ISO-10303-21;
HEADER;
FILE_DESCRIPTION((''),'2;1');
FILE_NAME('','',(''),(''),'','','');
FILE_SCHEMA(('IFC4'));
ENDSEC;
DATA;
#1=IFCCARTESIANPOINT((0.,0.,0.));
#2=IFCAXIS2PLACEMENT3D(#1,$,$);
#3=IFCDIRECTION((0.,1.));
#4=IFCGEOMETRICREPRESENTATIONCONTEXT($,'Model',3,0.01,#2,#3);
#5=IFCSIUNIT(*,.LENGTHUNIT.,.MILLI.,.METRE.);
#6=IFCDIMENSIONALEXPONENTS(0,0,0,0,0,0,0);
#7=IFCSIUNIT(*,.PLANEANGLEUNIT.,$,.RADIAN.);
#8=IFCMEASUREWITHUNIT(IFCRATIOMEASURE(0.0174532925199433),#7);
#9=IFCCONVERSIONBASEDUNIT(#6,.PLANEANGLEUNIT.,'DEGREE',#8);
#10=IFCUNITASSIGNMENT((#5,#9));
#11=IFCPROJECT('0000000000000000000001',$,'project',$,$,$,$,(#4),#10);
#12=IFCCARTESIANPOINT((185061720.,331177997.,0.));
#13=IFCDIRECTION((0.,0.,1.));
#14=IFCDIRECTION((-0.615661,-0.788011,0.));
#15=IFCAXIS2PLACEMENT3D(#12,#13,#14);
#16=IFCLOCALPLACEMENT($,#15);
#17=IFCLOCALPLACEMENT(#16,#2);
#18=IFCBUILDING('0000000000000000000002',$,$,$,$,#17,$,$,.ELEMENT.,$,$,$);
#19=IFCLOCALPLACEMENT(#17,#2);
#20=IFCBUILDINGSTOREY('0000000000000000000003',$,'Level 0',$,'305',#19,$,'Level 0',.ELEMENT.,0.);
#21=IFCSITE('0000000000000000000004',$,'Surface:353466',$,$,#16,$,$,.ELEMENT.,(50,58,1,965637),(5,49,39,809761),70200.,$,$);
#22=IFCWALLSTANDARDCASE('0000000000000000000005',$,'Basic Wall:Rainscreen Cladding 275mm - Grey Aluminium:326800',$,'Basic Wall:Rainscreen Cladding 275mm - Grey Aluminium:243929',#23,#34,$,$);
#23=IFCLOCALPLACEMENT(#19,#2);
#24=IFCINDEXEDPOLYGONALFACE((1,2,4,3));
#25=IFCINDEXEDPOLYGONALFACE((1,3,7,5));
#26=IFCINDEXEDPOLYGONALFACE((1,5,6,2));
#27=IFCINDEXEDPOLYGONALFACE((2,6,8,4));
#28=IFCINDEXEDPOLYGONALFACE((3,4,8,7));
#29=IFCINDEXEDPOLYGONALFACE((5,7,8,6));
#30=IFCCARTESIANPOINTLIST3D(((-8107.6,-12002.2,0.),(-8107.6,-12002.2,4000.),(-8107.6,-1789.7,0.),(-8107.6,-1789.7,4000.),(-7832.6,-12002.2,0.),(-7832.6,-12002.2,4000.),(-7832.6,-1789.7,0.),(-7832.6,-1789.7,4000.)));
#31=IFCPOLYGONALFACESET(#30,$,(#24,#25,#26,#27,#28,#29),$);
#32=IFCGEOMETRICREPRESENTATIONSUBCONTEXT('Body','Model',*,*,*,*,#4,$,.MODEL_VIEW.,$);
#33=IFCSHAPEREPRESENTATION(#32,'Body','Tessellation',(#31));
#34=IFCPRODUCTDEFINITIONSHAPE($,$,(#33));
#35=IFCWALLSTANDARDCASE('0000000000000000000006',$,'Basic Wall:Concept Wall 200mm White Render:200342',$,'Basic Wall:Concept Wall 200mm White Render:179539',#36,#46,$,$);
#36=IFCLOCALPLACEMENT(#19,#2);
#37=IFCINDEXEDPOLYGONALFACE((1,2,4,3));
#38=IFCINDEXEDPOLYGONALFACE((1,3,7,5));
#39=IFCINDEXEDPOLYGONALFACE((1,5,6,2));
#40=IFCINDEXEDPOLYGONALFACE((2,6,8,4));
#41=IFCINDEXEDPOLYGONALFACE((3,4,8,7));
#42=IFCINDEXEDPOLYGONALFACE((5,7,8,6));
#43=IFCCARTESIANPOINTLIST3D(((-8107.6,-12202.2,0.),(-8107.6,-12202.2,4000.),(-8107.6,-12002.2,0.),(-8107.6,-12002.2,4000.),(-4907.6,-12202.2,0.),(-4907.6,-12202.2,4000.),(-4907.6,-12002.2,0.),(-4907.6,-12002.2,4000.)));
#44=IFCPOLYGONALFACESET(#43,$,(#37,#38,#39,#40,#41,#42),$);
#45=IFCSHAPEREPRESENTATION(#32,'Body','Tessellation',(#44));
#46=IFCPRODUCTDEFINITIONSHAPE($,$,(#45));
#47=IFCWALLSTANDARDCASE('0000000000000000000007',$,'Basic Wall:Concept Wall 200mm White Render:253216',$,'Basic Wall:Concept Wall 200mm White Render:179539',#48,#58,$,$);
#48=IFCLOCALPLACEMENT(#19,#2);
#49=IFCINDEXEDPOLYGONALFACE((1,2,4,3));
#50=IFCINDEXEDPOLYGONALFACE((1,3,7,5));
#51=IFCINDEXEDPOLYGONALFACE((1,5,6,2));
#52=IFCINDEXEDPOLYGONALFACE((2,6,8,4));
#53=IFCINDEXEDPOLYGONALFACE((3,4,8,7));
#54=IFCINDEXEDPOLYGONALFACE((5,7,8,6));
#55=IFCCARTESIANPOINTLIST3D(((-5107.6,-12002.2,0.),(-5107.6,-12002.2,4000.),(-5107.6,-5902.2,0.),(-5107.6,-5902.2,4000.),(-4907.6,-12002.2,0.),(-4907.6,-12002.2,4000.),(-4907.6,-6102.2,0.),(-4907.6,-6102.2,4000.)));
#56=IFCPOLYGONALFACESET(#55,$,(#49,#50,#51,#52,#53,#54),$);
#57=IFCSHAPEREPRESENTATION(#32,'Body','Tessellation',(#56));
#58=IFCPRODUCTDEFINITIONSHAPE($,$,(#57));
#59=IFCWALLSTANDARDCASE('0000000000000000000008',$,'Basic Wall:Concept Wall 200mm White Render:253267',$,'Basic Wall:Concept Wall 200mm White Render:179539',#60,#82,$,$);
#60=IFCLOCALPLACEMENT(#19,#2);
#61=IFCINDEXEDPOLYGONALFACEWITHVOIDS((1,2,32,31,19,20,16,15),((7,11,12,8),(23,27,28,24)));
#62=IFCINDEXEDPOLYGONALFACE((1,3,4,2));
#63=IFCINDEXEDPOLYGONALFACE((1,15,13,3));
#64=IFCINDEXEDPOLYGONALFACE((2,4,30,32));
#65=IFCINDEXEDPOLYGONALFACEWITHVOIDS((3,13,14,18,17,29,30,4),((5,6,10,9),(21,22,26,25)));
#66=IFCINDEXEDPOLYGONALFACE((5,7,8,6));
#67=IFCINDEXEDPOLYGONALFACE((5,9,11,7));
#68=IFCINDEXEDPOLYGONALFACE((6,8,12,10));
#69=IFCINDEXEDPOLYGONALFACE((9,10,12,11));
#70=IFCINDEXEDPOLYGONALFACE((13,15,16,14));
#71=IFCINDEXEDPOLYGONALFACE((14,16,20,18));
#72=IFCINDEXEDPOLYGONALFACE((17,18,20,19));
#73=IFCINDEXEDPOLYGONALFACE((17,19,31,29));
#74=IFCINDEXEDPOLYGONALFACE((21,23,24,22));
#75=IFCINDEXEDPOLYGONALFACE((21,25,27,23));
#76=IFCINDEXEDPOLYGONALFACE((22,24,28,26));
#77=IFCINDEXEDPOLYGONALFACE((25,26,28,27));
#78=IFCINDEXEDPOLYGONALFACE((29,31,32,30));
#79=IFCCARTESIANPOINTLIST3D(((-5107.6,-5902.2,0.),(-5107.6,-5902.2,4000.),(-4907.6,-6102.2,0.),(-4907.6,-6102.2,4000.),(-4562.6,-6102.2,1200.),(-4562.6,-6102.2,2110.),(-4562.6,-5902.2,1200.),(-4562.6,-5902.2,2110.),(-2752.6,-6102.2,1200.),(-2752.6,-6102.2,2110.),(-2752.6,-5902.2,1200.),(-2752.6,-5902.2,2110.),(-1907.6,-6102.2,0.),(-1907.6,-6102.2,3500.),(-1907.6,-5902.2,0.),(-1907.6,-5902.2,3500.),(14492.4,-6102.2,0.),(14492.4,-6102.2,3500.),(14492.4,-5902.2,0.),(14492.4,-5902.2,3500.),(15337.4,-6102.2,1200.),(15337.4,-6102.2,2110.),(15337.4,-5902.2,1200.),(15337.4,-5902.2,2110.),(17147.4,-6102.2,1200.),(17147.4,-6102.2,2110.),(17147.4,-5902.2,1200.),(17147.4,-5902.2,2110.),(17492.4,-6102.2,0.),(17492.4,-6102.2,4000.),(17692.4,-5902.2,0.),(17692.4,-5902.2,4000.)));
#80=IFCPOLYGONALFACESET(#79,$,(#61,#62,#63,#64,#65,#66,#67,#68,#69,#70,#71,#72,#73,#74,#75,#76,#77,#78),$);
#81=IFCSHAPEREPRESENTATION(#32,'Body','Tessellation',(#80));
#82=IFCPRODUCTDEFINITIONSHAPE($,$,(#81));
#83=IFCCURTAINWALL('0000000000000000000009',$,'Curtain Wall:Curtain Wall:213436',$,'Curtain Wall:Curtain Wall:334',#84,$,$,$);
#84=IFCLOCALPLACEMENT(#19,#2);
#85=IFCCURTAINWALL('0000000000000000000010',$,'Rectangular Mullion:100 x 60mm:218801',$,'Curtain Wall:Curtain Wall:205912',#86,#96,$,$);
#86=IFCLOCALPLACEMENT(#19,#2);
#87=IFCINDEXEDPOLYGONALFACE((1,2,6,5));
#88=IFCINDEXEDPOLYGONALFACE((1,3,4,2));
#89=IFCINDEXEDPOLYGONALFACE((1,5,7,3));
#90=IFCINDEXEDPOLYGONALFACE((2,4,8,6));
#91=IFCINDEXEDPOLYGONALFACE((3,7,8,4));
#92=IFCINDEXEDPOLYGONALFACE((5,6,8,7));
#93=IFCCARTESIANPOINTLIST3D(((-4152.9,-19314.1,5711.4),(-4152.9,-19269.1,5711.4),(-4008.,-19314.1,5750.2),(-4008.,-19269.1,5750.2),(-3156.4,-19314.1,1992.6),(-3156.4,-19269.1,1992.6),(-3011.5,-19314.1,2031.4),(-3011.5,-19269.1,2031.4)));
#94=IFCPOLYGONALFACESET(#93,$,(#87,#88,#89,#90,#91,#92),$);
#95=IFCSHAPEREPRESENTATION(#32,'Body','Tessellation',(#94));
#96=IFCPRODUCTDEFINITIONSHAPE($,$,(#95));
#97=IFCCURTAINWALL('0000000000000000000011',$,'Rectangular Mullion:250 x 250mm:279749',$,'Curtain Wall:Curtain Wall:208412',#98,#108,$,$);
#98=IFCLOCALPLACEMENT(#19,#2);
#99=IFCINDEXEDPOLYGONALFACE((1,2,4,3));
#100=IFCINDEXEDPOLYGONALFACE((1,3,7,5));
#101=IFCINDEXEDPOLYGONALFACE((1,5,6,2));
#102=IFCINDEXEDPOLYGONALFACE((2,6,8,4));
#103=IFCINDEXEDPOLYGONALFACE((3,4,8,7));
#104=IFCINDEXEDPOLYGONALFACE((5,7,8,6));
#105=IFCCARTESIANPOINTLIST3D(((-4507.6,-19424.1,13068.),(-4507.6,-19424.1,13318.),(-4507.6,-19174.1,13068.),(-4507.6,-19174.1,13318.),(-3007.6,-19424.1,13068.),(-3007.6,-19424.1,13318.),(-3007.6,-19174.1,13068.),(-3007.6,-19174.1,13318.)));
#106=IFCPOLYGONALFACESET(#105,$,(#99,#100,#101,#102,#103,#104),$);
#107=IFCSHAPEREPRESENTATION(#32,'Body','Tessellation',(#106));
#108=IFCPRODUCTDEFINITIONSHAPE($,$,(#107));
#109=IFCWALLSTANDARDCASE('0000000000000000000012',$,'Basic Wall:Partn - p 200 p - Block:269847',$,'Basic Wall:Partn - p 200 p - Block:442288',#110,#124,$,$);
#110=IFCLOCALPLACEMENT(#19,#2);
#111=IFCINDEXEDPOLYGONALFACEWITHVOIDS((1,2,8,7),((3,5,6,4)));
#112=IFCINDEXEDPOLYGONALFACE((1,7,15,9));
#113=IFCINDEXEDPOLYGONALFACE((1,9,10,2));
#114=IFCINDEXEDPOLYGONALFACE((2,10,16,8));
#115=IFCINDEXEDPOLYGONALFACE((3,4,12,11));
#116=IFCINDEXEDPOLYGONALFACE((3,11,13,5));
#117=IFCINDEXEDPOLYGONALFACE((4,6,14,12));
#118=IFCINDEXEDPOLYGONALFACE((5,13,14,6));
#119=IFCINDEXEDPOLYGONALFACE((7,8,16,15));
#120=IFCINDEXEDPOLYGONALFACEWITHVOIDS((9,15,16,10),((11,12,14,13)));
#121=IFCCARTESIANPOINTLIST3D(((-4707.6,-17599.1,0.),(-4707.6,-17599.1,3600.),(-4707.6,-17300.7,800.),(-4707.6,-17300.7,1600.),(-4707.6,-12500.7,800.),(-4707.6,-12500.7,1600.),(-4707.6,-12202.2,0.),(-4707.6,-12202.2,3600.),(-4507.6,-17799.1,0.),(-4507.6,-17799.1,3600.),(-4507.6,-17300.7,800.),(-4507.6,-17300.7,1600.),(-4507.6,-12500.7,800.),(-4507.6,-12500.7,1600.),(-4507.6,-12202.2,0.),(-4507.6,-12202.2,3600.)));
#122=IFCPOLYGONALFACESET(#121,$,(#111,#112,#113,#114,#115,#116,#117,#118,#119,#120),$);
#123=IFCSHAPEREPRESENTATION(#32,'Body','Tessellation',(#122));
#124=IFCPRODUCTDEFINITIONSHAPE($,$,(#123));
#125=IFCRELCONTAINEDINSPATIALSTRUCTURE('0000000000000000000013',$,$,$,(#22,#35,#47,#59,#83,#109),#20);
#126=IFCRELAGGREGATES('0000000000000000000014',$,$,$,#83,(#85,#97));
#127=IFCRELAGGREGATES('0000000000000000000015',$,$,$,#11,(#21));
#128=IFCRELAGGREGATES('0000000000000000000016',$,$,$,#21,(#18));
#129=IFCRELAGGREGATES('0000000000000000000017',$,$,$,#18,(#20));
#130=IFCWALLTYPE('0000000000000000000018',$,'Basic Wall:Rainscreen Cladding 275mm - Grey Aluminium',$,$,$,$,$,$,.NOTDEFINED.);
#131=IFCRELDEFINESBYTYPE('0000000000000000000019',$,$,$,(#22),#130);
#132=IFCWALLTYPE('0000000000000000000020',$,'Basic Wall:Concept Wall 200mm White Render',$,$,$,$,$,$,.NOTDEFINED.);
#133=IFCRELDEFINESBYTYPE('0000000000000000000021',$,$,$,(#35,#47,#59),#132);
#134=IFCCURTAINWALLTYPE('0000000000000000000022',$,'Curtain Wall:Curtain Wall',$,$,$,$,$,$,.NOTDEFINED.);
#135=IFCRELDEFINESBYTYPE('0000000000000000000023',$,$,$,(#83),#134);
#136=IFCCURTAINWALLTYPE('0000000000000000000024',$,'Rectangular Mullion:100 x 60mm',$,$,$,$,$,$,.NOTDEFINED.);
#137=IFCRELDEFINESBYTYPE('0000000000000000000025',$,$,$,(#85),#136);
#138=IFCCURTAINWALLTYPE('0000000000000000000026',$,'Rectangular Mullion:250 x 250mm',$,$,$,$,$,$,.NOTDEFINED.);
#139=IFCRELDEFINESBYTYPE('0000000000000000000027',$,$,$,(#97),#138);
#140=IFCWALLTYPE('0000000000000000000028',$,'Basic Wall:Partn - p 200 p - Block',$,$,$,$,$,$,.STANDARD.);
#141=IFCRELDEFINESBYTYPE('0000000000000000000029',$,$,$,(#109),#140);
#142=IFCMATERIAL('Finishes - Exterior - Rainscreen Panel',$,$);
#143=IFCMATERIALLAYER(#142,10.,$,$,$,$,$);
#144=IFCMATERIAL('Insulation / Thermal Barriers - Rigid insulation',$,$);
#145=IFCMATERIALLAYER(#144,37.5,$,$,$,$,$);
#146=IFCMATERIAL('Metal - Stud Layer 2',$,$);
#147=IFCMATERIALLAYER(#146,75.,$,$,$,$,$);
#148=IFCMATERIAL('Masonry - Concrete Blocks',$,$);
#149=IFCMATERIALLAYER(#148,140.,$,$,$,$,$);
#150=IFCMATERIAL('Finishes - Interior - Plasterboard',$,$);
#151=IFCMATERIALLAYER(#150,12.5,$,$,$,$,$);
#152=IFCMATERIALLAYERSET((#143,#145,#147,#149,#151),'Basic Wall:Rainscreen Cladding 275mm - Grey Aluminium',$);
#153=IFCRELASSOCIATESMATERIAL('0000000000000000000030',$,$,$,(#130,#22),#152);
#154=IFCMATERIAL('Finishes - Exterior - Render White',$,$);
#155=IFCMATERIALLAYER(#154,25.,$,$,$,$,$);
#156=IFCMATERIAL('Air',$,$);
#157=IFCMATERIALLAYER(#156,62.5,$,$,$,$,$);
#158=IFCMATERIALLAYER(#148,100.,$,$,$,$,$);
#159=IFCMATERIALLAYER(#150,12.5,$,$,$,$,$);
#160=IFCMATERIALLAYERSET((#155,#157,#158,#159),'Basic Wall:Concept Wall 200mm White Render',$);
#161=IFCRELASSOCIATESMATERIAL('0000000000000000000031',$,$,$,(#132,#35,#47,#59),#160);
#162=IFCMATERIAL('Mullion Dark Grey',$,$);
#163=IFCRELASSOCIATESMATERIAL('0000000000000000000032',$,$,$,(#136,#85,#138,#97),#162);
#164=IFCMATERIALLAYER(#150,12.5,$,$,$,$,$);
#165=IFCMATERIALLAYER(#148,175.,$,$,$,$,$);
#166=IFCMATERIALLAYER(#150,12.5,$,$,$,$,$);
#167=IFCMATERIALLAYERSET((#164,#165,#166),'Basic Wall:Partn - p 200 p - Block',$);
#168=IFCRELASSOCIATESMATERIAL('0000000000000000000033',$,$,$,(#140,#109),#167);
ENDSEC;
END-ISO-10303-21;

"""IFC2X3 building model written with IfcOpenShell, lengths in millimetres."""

from ifc_helpers import new_model, entity, si_unit, converted_unit, direction, frame, frame_2d, origin, origin_2d_with_axis, place, context, subcontext, project, spatial, polyline, rectangle, outline, extrude, clip, halfspace, bounded_halfspace, source, transform, mapped, material, layer, layer_set, layer_usage, type_object, type_shapes, element, aggregate, save


model = new_model("IFC2X3")

# Units and contexts
model_context = context("Model", 3, precision=0.01, world=origin(), true_north=direction((0.0, 1.0)))
body_context = subcontext(model_context, "Body", "Model", "MODEL_VIEW")
ifc_project = project(units=[si_unit("LENGTHUNIT", "METRE", prefix="MILLI"), converted_unit("PLANEANGLEUNIT", "DEGREE", entity("IfcRatioMeasure", 0.0174532925199433), si_unit("PLANEANGLEUNIT", "RADIAN"), dimensions=[0, 0, 0, 0, 0, 0, 0])], contexts=[model_context])

# Site, building, storey
site_placement = place(None, frame((185061720.0, 331177997.0, 0.0), z_axis=(0.0, 0.0, 1.0), x_axis=(-0.615661, -0.788011, 0.0)))
site = spatial("IfcSite", under=ifc_project, at=site_placement, Name="Surface:353466", CompositionType="ELEMENT", RefLatitude=(50, 58, 1, 965637), RefLongitude=(5, 49, 39, 809761), RefElevation=70200.0)
building_placement = place(site_placement, origin())
building = spatial("IfcBuilding", under=site, at=building_placement, CompositionType="ELEMENT")
storey_placement = place(building_placement, origin())
storey = spatial("IfcBuildingStorey", under=building, at=storey_placement, Name="Level 0", ObjectType="305", LongName="Level 0", CompositionType="ELEMENT", Elevation=0.0)

# Walls
ifc_material_1 = material(Name="Finishes - Exterior - Rainscreen Panel")
ifc_layer_1 = layer(ifc_material_1, 10.0)
ifc_material_2 = material(Name="Insulation / Thermal Barriers - Rigid insulation")
ifc_layer_2 = layer(ifc_material_2, 37.5)
ifc_material_3 = material(Name="Metal - Stud Layer 2")
ifc_layer_3 = layer(ifc_material_3, 75.0)
ifc_material_4 = material(Name="Masonry - Concrete Blocks")
ifc_layer_4 = layer(ifc_material_4, 140.0)
ifc_material_5 = material(Name="Finishes - Interior - Plasterboard")
ifc_layer_5 = layer(ifc_material_5, 12.5)
ifc_layer_set_1 = layer_set([ifc_layer_1, ifc_layer_2, ifc_layer_3, ifc_layer_4, ifc_layer_5], Name="Basic Wall:Rainscreen Cladding 275mm - Grey Aluminium")
ifc_layer_usage_1 = layer_usage(ifc_layer_set_1, "AXIS2", "NEGATIVE", 137.5)
wall_type_1 = type_object("IfcWallType", Name="Basic Wall:Rainscreen Cladding 275mm - Grey Aluminium", PredefinedType="NOTDEFINED", material=ifc_layer_set_1)
wall_1_placement = place(storey_placement, frame((-7970.1, -1789.7, 0.0), z_axis=(0.0, 0.0, 1.0), x_axis=(0.0, -1.0, 0.0)))
element("IfcWallStandardCase", 1, at=wall_1_placement, inside=storey, type_object=wall_type_1, material=ifc_layer_usage_1, Name="Basic Wall:Rainscreen Cladding 275mm - Grey Aluminium:326800", ObjectType="Basic Wall:Rainscreen Cladding 275mm - Grey Aluminium:243929", context=body_context, shape_type="Clipping", body=[
    clip(extrude(rectangle(XDim=10212.5, YDim=275.0, at=frame_2d((5106.2, 0.0), x_axis=(-1.0, 0.0))), origin(), (0.0, 0.0, 1.0), 4000.0), halfspace(origin(), True)),
])
ifc_material_6 = material(Name="Finishes - Exterior - Render White")
ifc_layer_6 = layer(ifc_material_6, 25.0)
ifc_material_7 = material(Name="Air")
ifc_layer_7 = layer(ifc_material_7, 62.5)
ifc_layer_8 = layer(ifc_material_4, 100.0)
ifc_layer_9 = layer(ifc_material_5, 12.5)
ifc_layer_set_2 = layer_set([ifc_layer_6, ifc_layer_7, ifc_layer_8, ifc_layer_9], Name="Basic Wall:Concept Wall 200mm White Render")
ifc_layer_usage_2 = layer_usage(ifc_layer_set_2, "AXIS2", "NEGATIVE", 100.0)
wall_type_2 = type_object("IfcWallType", Name="Basic Wall:Concept Wall 200mm White Render", PredefinedType="NOTDEFINED", material=ifc_layer_set_2)
wall_2_placement = place(storey_placement, frame((-8107.6, -12102.2, 0.0)))
element("IfcWallStandardCase", 2, at=wall_2_placement, inside=storey, type_object=wall_type_2, material=ifc_layer_usage_2, Name="Basic Wall:Concept Wall 200mm White Render:200342", ObjectType="Basic Wall:Concept Wall 200mm White Render:179539", context=body_context, shape_type="Clipping", body=[
    clip(extrude(rectangle(XDim=3200.0, YDim=200.0, at=frame_2d((1600.0, 0.0), x_axis=(-1.0, 0.0))), origin(), (0.0, 0.0, 1.0), 4000.0), halfspace(origin(), True)),
])
ifc_layer_usage_3 = layer_usage(ifc_layer_set_2, "AXIS2", "NEGATIVE", 100.0)
wall_3_placement = place(storey_placement, frame((-5007.6, -12002.2, 0.0), z_axis=(0.0, 0.0, 1.0), x_axis=(0.0, 1.0, 0.0)))
element("IfcWallStandardCase", 3, at=wall_3_placement, inside=storey, type_object=wall_type_2, material=ifc_layer_usage_3, Name="Basic Wall:Concept Wall 200mm White Render:253216", ObjectType="Basic Wall:Concept Wall 200mm White Render:179539", context=body_context, shape_type="Clipping", body=[
    clip(extrude(outline(polyline([(5900.0, -100.0), (6100.0, 100.0), (0.0, 100.0), (0.0, -100.0), (5900.0, -100.0)])), origin(), (0.0, 0.0, 1.0), 4000.0), halfspace(origin(), True)),
])

# Wall, openings
ifc_layer_usage_4 = layer_usage(ifc_layer_set_2, "AXIS2", "NEGATIVE", 100.0)
wall_4_placement = place(storey_placement, frame((-5107.6, -6002.2, 0.0)))
wall_4 = element("IfcWallStandardCase", 4, at=wall_4_placement, inside=storey, type_object=wall_type_2, material=ifc_layer_usage_4, Name="Basic Wall:Concept Wall 200mm White Render:253267", ObjectType="Basic Wall:Concept Wall 200mm White Render:179539", context=body_context, shape_type="Clipping", body=[
    clip(extrude(outline(polyline([(200.0, -100.0), (22600.0, -100.0), (22800.0, 100.0), (0.0, 100.0), (200.0, -100.0)])), origin(), (0.0, 0.0, 1.0), 4000.0), halfspace(origin(), True)),
])
opening_1_placement = place(wall_4_placement, origin())
element("IfcOpeningElement", 5, at=opening_1_placement, cuts=wall_4, ObjectType="Opening", context=body_context, shape_type="SweptSolid", body=[
    extrude(rectangle(XDim=3800.0, YDim=16400.0, at=frame_2d((0.0, 0.0), x_axis=(1.0, 0.0))), frame((11400.0, -100.0, 1600.0), z_axis=(0.0, 1.0, 0.0), x_axis=(0.0, 0.0, -1.0)), (0.0, 0.0, 1.0), 200.0),
])
opening_2_placement = place(wall_4_placement, origin())
element("IfcOpeningElement", 6, at=opening_2_placement, cuts=wall_4, ObjectType="Opening", context=body_context, shape_type="SweptSolid", body=[
    extrude(rectangle(XDim=910.0, YDim=1810.0, at=frame_2d((0.0, 0.0), x_axis=(0.0, 1.0))), frame((1450.0, -1624.0, 1655.0), z_axis=(0.0, 1.0, 0.0), x_axis=(1.0, 0.0, 0.0)), (0.0, 0.0, 1.0), 3048.0),
])
opening_3_placement = place(wall_4_placement, origin())
element("IfcOpeningElement", 7, at=opening_3_placement, cuts=wall_4, ObjectType="Opening", context=body_context, shape_type="SweptSolid", body=[
    extrude(rectangle(XDim=910.0, YDim=1810.0, at=frame_2d((0.0, 0.0), x_axis=(0.0, 1.0))), frame((21350.0, -1624.0, 1655.0), z_axis=(0.0, 1.0, 0.0), x_axis=(1.0, 0.0, 0.0)), (0.0, 0.0, 1.0), 3048.0),
])
opening_4_placement = place(wall_4_placement, frame((545.0, -100.0, 1200.0)))
element("IfcOpeningElement", 8, at=opening_4_placement, cuts=wall_4, ObjectType="Opening", context=body_context, shape_type="SweptSolid", body=[
    extrude(rectangle(XDim=910.0, YDim=1810.0, at=frame_2d((455.0, 905.0), x_axis=(-1.0, 0.0))), frame((0.0, 0.0, 0.0), z_axis=(0.0, 1.0, 0.0), x_axis=(0.0, 0.0, 1.0)), (0.0, 0.0, 1.0), 200.0),
])
opening_5_placement = place(wall_4_placement, frame((20445.0, -100.0, 1200.0)))
element("IfcOpeningElement", 9, at=opening_5_placement, cuts=wall_4, ObjectType="Opening", context=body_context, shape_type="SweptSolid", body=[
    extrude(rectangle(XDim=910.0, YDim=1810.0, at=frame_2d((455.0, 905.0), x_axis=(-1.0, 0.0))), frame((0.0, 0.0, 0.0), z_axis=(0.0, 1.0, 0.0), x_axis=(0.0, 0.0, 1.0)), (0.0, 0.0, 1.0), 200.0),
])

# Curtain walls
curtain_wall_type_1 = type_object("IfcCurtainWallType", Name="Curtain Wall:Curtain Wall", PredefinedType="NOTDEFINED")
curtain_wall_1_placement = place(storey_placement, origin())
curtain_wall_1 = element("IfcCurtainWall", 10, at=curtain_wall_1_placement, inside=storey, type_object=curtain_wall_type_1, Name="Curtain Wall:Curtain Wall:213436", ObjectType="Curtain Wall:Curtain Wall:334")
ifc_material_8 = material(Name="Mullion Dark Grey")
curtain_wall_type_2 = type_object("IfcCurtainWallType", Name="Rectangular Mullion:100 x 60mm", PredefinedType="NOTDEFINED", material=ifc_material_8)
shared_shape_1 = source(origin(), body_context, "Body", "SweptSolid", [
    extrude(rectangle(XDim=150.0, YDim=45.0, at=frame_2d((0.0, 0.0), x_axis=(1.0, 0.0))), frame((0.0, -7.5, -3850.0)), (0.0, 0.0, 1.0), 3850.0),
])
type_shapes(curtain_wall_type_2, [shared_shape_1])
curtain_wall_2_placement = place(storey_placement, frame((-3084.0, -19299.1, 2012.0), z_axis=(0.258819, 0.0, -0.965926), x_axis=(0.965926, 0.0, 0.258819)))
curtain_wall_2 = element("IfcCurtainWall", 11, at=curtain_wall_2_placement, type_object=curtain_wall_type_2, material=ifc_material_8, Name="Rectangular Mullion:100 x 60mm:218801", ObjectType="Curtain Wall:Curtain Wall:205912", context=body_context, shape_type="MappedRepresentation", body=[
    mapped(shared_shape_1, transform((0.0, 0.0, 0.0), scale=1.0)),
])
curtain_wall_type_3 = type_object("IfcCurtainWallType", Name="Rectangular Mullion:250 x 250mm", PredefinedType="NOTDEFINED", material=ifc_material_8)
shared_shape_2 = source(origin(), body_context, "Body", "SweptSolid", [
    extrude(rectangle(XDim=250.0, YDim=250.0, at=origin_2d_with_axis()), frame((-125.0, 0.0, -1500.0), z_axis=(0.0, 0.0, 1.0), x_axis=(-1.0, 0.0, 0.0)), (0.0, 0.0, 1.0), 1500.0),
])
type_shapes(curtain_wall_type_3, [shared_shape_2])
curtain_wall_3_placement = place(storey_placement, frame((-3007.6, -19299.1, 13318.0), z_axis=(1.0, 0.0, 0.0), x_axis=(0.0, 0.0, 1.0)))
curtain_wall_3 = element("IfcCurtainWall", 12, at=curtain_wall_3_placement, type_object=curtain_wall_type_3, material=ifc_material_8, Name="Rectangular Mullion:250 x 250mm:279749", ObjectType="Curtain Wall:Curtain Wall:208412", context=body_context, shape_type="MappedRepresentation", body=[
    mapped(shared_shape_2, transform((0.0, 0.0, 0.0), scale=1.0)),
])
aggregate(curtain_wall_1, [curtain_wall_2, curtain_wall_3])

# Wall, opening
ifc_layer_10 = layer(ifc_material_5, 12.5)
ifc_layer_11 = layer(ifc_material_4, 175.0)
ifc_layer_12 = layer(ifc_material_5, 12.5)
ifc_layer_set_3 = layer_set([ifc_layer_10, ifc_layer_11, ifc_layer_12], Name="Basic Wall:Partn - p 200 p - Block")
ifc_layer_usage_5 = layer_usage(ifc_layer_set_3, "AXIS2", "POSITIVE", -100.0)
wall_type_3 = type_object("IfcWallType", Name="Basic Wall:Partn - p 200 p - Block", PredefinedType="STANDARD", material=ifc_layer_set_3)
wall_5_placement = place(storey_placement, frame((-4607.6, -17799.1, 0.0), z_axis=(0.0, 0.0, 1.0), x_axis=(0.0, 1.0, 0.0)))
wall_5 = element("IfcWallStandardCase", 13, at=wall_5_placement, inside=storey, type_object=wall_type_3, material=ifc_layer_usage_5, Name="Basic Wall:Partn - p 200 p - Block:269847", ObjectType="Basic Wall:Partn - p 200 p - Block:442288", context=body_context, shape_type="Clipping", body=[
    clip(extrude(outline(polyline([(5596.9, -100.0), (5596.9, 100.0), (200.0, 100.0), (0.0, -100.0), (5596.9, -100.0)])), origin(), (0.0, 0.0, 1.0), 3600.0), bounded_halfspace(frame((0.0, -100.0, 3600.0), z_axis=(0.0, 0.0, -1.0), x_axis=(0.0, -1.0, 0.0)), True, frame((0.0, -100.0, 3600.0)), polyline([(0.0, 0.0), (5596.9, 0.0), (5596.9, 200.0), (200.0, 200.0), (0.0, 0.0)]))),
])
opening_6_placement = place(wall_5_placement, origin())
element("IfcOpeningElement", 14, at=opening_6_placement, cuts=wall_5, ObjectType="Opening", context=body_context, shape_type="SweptSolid", body=[
    extrude(rectangle(XDim=800.0, YDim=4800.0, at=frame_2d((0.0, 0.0), x_axis=(0.0, 1.0))), frame((2898.5, -252.4, 1200.0), z_axis=(0.0, 1.0, 0.0), x_axis=(-1.0, 0.0, 0.0)), (0.0, 0.0, 1.0), 504.8),
])

save(model, "model.ifc")
